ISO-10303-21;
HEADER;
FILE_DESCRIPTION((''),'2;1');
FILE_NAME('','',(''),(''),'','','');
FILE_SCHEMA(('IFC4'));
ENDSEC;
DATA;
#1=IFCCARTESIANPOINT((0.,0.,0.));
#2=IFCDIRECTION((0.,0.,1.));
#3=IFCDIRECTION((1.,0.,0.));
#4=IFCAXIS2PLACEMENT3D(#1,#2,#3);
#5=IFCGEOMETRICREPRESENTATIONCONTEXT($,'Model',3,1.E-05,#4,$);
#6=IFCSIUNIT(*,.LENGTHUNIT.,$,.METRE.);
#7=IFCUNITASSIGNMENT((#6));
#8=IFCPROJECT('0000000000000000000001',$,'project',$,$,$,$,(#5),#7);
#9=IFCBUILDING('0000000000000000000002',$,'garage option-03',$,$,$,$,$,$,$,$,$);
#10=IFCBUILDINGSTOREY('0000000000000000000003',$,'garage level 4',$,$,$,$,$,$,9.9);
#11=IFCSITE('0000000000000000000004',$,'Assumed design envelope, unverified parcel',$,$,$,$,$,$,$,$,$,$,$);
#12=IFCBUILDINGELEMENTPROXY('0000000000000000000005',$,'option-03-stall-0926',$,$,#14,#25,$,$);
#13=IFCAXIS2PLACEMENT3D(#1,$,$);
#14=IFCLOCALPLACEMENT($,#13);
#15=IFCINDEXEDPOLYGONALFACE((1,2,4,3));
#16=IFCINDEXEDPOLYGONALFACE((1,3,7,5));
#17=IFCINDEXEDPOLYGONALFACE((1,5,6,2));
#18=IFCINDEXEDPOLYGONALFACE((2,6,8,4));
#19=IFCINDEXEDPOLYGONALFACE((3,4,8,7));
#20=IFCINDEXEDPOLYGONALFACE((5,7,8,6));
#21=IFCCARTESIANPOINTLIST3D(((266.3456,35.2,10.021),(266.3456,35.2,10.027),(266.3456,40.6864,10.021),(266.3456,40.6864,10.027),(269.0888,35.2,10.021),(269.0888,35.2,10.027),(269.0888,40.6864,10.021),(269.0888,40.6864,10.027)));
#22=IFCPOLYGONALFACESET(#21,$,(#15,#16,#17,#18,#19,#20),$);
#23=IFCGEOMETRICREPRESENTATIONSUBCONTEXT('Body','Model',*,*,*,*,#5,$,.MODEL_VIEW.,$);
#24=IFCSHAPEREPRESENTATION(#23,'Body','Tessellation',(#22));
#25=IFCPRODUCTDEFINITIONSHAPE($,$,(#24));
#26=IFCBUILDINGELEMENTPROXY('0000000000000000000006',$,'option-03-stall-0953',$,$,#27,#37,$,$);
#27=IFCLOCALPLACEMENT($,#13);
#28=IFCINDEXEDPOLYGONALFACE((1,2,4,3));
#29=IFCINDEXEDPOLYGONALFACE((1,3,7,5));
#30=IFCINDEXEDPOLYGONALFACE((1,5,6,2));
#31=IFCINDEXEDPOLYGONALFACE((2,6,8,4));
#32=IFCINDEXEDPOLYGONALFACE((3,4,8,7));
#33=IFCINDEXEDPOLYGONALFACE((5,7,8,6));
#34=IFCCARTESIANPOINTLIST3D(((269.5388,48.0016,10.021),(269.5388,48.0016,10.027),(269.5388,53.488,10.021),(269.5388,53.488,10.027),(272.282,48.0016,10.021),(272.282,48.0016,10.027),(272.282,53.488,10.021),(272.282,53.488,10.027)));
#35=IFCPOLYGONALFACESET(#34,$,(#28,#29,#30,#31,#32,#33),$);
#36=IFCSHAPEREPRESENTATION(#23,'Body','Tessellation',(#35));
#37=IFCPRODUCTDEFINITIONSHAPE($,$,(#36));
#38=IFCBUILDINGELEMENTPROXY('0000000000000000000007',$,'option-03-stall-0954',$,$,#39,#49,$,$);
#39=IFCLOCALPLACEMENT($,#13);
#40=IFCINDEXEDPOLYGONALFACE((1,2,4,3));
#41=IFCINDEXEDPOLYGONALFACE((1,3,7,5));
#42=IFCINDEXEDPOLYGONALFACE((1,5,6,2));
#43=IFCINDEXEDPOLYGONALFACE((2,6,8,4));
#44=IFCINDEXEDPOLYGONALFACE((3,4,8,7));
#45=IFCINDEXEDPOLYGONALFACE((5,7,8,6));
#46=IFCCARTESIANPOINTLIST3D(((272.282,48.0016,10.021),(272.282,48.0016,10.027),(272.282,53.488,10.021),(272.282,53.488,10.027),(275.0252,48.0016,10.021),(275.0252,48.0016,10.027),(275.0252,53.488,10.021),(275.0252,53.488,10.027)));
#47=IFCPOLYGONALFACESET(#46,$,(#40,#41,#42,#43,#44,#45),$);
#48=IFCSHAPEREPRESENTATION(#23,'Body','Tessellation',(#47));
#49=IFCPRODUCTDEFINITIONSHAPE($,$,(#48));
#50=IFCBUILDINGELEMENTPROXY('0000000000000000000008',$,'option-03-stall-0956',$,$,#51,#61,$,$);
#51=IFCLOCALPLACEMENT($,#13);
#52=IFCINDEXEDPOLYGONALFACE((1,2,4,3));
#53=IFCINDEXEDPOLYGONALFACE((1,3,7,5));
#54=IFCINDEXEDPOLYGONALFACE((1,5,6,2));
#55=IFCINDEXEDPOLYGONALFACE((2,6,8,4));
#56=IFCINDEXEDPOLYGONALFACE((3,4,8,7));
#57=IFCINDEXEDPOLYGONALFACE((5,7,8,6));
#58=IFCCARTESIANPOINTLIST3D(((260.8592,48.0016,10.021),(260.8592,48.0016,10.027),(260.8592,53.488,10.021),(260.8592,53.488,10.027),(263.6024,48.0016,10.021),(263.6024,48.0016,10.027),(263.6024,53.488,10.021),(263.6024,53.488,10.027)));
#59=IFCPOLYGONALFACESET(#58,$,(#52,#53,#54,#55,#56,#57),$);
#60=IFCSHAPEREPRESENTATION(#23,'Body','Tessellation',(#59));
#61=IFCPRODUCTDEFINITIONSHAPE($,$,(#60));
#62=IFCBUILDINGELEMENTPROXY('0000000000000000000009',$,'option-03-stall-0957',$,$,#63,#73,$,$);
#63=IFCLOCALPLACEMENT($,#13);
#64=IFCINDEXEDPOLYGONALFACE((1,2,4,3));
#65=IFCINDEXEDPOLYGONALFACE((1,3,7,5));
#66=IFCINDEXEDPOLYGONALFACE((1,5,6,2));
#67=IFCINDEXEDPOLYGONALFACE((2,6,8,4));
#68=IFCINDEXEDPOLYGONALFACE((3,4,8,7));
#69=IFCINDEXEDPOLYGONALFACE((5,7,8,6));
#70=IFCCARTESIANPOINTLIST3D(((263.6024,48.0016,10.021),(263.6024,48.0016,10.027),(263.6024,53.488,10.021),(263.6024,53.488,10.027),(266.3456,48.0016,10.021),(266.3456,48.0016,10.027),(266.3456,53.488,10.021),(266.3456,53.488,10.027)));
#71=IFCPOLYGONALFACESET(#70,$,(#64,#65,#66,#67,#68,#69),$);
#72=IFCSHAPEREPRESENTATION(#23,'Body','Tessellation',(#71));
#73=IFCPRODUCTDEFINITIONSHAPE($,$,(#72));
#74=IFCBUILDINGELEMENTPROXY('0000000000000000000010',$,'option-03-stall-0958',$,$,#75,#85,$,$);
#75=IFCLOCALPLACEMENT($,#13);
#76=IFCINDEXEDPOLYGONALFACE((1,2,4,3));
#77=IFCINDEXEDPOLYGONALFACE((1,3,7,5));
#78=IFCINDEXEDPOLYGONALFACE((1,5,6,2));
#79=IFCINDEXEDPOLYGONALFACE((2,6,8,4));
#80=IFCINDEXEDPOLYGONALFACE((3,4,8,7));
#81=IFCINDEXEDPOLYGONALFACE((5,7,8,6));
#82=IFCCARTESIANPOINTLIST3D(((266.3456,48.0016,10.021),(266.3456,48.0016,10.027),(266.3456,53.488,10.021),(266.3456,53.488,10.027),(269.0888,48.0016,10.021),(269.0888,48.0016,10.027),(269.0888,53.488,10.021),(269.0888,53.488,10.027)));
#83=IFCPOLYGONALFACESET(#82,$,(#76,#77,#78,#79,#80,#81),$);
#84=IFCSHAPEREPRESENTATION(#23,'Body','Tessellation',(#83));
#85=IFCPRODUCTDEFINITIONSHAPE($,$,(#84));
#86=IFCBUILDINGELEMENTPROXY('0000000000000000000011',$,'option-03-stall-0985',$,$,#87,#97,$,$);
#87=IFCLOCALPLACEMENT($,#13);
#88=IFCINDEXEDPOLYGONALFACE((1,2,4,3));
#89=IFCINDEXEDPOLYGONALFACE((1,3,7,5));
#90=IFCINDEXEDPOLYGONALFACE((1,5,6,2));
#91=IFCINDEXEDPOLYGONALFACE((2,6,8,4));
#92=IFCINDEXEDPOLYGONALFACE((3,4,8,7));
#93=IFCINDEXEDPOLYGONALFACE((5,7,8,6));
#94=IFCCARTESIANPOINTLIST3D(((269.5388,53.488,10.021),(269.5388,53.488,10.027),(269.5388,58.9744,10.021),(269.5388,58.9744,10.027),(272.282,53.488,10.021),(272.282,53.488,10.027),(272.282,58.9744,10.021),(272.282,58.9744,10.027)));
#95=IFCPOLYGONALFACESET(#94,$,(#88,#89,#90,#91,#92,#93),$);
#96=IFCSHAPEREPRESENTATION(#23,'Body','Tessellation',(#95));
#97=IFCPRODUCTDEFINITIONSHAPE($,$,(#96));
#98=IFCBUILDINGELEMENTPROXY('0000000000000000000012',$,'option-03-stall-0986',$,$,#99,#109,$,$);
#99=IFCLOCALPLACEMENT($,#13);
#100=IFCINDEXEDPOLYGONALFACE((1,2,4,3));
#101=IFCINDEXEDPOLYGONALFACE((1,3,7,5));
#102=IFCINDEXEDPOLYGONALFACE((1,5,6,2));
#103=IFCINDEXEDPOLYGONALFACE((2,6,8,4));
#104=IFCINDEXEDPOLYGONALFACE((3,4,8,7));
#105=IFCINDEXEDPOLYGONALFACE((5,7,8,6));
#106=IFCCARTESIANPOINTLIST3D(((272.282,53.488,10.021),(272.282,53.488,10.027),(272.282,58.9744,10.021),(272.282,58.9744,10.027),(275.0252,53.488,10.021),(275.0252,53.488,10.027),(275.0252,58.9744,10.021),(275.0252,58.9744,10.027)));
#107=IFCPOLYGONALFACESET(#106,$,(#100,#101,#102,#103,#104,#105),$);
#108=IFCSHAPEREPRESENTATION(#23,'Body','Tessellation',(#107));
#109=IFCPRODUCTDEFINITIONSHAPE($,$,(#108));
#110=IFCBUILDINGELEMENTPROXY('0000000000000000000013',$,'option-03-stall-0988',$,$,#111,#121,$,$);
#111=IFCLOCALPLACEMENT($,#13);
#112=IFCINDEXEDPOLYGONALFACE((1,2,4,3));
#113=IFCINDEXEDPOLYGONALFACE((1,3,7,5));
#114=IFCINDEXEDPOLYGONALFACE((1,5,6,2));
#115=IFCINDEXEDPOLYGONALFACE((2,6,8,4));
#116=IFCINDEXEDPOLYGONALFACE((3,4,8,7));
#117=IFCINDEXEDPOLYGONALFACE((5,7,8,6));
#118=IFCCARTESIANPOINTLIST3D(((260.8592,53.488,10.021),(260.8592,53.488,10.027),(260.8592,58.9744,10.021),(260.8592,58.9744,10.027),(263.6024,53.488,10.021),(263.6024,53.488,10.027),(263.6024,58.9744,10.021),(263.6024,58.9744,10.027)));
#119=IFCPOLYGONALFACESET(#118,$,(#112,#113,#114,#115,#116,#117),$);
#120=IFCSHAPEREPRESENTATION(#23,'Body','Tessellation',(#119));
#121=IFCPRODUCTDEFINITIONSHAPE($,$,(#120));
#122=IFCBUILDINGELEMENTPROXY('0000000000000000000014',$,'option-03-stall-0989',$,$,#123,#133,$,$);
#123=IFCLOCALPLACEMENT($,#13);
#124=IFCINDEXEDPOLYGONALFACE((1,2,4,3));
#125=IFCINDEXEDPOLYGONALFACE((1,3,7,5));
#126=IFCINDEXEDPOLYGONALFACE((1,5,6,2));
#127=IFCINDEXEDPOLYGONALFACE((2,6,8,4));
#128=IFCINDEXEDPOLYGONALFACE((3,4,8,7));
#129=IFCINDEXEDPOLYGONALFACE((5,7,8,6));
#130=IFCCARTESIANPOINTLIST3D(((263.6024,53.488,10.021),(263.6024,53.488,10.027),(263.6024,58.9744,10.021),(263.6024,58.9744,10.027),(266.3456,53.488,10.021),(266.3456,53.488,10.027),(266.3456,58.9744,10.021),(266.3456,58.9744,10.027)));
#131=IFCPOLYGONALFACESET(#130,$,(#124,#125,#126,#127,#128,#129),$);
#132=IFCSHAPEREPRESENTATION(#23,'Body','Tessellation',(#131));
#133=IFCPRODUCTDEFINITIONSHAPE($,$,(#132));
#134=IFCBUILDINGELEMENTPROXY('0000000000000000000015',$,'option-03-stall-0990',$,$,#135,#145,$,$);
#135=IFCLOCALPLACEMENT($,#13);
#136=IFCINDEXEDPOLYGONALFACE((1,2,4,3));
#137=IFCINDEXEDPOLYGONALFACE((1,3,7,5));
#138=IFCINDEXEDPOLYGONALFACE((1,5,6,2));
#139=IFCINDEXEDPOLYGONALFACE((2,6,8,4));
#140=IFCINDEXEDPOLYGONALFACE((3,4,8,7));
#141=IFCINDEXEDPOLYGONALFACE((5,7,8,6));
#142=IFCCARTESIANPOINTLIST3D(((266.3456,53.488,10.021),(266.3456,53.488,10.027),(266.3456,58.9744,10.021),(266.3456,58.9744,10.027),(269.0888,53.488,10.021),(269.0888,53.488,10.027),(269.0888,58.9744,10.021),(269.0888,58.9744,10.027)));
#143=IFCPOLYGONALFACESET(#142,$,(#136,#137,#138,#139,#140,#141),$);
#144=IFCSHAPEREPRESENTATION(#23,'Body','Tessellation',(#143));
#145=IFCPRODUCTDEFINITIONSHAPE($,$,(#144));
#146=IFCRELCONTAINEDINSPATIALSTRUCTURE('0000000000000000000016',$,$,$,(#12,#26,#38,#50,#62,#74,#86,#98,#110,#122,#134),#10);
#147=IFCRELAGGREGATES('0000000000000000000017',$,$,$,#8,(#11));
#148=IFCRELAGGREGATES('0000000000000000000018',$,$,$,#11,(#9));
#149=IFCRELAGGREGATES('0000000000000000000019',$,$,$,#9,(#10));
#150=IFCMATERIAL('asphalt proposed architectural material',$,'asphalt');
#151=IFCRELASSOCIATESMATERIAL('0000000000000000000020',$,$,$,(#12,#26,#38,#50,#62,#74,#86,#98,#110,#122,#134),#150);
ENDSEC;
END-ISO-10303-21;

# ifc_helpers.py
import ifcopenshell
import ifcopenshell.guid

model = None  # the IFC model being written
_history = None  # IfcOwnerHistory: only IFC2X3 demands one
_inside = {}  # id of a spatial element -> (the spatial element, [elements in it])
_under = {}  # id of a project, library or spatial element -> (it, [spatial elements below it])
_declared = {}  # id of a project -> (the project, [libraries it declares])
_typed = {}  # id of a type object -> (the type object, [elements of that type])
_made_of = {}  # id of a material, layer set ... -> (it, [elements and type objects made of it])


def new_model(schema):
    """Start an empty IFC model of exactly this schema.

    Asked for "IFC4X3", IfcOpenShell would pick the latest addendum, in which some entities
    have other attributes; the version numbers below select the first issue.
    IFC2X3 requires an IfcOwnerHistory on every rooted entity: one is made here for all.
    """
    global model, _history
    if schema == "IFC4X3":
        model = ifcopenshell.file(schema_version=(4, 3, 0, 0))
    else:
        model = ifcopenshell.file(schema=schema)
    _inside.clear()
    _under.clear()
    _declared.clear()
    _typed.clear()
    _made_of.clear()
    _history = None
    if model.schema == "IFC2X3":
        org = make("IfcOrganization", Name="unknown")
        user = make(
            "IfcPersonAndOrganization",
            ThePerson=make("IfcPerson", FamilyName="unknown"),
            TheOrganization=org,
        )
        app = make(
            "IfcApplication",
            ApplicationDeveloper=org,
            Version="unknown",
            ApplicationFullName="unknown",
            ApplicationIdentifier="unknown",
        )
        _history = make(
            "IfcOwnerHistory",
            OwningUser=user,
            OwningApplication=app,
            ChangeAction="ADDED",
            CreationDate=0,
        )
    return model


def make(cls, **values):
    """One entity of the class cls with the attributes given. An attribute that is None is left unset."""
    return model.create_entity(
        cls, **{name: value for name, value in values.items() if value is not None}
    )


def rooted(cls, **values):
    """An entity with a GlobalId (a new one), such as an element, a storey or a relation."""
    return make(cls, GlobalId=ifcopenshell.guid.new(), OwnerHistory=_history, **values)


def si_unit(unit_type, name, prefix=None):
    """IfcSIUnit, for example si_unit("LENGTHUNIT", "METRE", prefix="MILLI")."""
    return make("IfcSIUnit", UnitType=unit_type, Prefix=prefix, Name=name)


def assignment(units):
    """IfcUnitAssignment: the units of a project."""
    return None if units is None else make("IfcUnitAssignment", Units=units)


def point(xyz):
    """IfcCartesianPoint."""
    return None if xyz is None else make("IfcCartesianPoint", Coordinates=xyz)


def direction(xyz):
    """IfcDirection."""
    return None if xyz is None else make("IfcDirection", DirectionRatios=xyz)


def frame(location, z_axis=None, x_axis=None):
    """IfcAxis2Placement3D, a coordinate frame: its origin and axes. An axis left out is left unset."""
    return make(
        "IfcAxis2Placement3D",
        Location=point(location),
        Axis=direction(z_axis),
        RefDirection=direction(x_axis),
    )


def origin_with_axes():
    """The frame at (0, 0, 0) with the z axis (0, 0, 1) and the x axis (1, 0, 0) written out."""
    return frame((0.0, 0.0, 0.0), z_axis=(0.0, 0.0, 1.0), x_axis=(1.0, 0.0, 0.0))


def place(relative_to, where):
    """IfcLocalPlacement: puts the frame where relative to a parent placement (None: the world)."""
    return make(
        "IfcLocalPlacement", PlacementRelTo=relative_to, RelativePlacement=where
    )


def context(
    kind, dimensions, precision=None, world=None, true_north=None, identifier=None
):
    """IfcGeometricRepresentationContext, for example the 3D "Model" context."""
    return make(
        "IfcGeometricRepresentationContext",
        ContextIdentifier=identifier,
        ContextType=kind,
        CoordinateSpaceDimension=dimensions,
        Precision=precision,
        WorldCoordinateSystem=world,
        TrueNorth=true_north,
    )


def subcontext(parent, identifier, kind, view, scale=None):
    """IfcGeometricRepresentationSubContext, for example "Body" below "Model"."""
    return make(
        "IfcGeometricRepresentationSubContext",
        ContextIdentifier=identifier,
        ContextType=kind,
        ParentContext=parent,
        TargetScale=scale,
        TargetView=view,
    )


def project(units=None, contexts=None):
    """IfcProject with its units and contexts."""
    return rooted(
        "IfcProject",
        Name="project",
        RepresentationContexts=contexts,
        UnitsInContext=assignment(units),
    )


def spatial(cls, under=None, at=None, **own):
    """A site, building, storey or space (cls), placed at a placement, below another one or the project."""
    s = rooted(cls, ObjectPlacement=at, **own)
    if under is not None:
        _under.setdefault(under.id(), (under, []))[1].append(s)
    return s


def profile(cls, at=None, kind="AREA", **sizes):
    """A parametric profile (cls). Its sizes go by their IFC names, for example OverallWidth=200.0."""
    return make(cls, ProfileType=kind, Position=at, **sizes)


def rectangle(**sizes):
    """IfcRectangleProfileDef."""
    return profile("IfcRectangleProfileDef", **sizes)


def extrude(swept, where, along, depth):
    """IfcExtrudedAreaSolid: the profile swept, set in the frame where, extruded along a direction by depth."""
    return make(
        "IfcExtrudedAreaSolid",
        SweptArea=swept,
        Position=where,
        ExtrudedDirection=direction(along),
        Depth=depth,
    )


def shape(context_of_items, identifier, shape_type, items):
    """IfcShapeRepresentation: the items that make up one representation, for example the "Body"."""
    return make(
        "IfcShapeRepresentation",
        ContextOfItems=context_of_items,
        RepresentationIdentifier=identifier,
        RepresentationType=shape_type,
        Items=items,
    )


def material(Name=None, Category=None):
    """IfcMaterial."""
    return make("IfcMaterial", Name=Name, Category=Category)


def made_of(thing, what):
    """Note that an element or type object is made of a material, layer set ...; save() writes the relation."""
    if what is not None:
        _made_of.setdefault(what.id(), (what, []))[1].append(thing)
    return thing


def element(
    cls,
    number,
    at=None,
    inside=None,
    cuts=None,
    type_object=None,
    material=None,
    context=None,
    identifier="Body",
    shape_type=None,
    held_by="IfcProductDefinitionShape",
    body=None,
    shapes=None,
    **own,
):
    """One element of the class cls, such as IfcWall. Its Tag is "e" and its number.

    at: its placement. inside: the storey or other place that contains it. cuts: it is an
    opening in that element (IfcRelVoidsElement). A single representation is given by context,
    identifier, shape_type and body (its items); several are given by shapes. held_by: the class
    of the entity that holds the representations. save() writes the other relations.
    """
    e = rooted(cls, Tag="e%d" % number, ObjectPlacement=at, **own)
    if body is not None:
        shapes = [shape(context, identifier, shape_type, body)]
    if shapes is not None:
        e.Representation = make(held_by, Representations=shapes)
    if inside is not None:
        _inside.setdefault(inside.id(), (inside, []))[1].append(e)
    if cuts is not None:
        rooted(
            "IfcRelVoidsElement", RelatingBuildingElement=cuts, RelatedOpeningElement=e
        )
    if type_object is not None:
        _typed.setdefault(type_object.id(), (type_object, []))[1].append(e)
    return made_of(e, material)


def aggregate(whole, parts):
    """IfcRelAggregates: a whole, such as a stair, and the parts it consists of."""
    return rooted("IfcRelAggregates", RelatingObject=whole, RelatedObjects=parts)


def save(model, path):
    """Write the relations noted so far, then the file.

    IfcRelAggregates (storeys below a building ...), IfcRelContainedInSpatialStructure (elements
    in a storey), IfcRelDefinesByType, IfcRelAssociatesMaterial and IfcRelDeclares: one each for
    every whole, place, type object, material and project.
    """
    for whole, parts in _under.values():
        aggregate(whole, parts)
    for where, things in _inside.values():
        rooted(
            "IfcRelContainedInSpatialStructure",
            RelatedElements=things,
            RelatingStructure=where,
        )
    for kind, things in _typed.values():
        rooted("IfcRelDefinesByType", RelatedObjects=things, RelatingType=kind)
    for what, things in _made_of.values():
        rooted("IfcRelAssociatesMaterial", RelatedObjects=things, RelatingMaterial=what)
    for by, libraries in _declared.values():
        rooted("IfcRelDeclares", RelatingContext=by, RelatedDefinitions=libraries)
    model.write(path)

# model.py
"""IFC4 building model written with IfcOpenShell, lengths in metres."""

from ifc_helpers import new_model, si_unit, frame, origin_with_axes, place, context, subcontext, project, spatial, rectangle, extrude, material, element, save


model = new_model("IFC4")

# Units and contexts
model_context = context("Model", 3, precision=1e-05, world=origin_with_axes())
body_context = subcontext(model_context, "Body", "Model", "MODEL_VIEW")
ifc_project = project(units=[si_unit("LENGTHUNIT", "METRE")], contexts=[model_context])

# Site, building, storey
site = spatial("IfcSite", under=ifc_project, Name="Assumed design envelope, unverified parcel")
building = spatial("IfcBuilding", under=site, Name="garage option-03")
storey = spatial("IfcBuildingStorey", under=building, Name="garage level 4", Elevation=9.9)

# Building element proxies
ifc_material_1 = material(Name="asphalt proposed architectural material", Category="asphalt")
for number, where, z_axis, x_axis, name in (
    (1, (267.7172, 37.9432, 10.021), (0.0, 0.0, 1.0), (1.0, 0.0, 0.0), "option-03-stall-0926"),
    (2, (270.9104, 50.7448, 10.021), (0.0, 0.0, 1.0), (1.0, 0.0, 0.0), "option-03-stall-0953"),
    (3, (273.6536, 50.7448, 10.021), (0.0, 0.0, 1.0), (1.0, 0.0, 0.0), "option-03-stall-0954"),
    (4, (262.2308, 50.7448, 10.021), (0.0, 0.0, 1.0), (1.0, 0.0, 0.0), "option-03-stall-0956"),
    (5, (264.974, 50.7448, 10.021), (0.0, 0.0, 1.0), (1.0, 0.0, 0.0), "option-03-stall-0957"),
    (6, (267.7172, 50.7448, 10.021), (0.0, 0.0, 1.0), (1.0, 0.0, 0.0), "option-03-stall-0958"),
):
    element("IfcBuildingElementProxy", number, at=place(None, frame(where, z_axis=z_axis, x_axis=x_axis)), inside=storey, material=ifc_material_1, Name=name, context=body_context, shape_type="SweptSolid", body=[
        extrude(rectangle(XDim=2.7432, YDim=5.4864), origin_with_axes(), (0.0, 0.0, 1.0), 0.006),
    ])
for number, where, z_axis, x_axis, name in (
    (7, (270.9104, 56.2312, 10.021), (0.0, 0.0, 1.0), (1.0, 0.0, 0.0), "option-03-stall-0985"),
    (8, (273.6536, 56.2312, 10.021), (0.0, 0.0, 1.0), (1.0, 0.0, 0.0), "option-03-stall-0986"),
    (9, (262.2308, 56.2312, 10.021), (0.0, 0.0, 1.0), (1.0, 0.0, 0.0), "option-03-stall-0988"),
    (10, (264.974, 56.2312, 10.021), (0.0, 0.0, 1.0), (1.0, 0.0, 0.0), "option-03-stall-0989"),
    (11, (267.7172, 56.2312, 10.021), (0.0, 0.0, 1.0), (1.0, 0.0, 0.0), "option-03-stall-0990"),
):
    element("IfcBuildingElementProxy", number, at=place(None, frame(where, z_axis=z_axis, x_axis=x_axis)), inside=storey, material=ifc_material_1, Name=name, context=body_context, shape_type="SweptSolid", body=[
        extrude(rectangle(XDim=2.7432, YDim=5.4864), origin_with_axes(), (0.0, 0.0, 1.0), 0.006),
    ])

save(model, "model.ifc")
